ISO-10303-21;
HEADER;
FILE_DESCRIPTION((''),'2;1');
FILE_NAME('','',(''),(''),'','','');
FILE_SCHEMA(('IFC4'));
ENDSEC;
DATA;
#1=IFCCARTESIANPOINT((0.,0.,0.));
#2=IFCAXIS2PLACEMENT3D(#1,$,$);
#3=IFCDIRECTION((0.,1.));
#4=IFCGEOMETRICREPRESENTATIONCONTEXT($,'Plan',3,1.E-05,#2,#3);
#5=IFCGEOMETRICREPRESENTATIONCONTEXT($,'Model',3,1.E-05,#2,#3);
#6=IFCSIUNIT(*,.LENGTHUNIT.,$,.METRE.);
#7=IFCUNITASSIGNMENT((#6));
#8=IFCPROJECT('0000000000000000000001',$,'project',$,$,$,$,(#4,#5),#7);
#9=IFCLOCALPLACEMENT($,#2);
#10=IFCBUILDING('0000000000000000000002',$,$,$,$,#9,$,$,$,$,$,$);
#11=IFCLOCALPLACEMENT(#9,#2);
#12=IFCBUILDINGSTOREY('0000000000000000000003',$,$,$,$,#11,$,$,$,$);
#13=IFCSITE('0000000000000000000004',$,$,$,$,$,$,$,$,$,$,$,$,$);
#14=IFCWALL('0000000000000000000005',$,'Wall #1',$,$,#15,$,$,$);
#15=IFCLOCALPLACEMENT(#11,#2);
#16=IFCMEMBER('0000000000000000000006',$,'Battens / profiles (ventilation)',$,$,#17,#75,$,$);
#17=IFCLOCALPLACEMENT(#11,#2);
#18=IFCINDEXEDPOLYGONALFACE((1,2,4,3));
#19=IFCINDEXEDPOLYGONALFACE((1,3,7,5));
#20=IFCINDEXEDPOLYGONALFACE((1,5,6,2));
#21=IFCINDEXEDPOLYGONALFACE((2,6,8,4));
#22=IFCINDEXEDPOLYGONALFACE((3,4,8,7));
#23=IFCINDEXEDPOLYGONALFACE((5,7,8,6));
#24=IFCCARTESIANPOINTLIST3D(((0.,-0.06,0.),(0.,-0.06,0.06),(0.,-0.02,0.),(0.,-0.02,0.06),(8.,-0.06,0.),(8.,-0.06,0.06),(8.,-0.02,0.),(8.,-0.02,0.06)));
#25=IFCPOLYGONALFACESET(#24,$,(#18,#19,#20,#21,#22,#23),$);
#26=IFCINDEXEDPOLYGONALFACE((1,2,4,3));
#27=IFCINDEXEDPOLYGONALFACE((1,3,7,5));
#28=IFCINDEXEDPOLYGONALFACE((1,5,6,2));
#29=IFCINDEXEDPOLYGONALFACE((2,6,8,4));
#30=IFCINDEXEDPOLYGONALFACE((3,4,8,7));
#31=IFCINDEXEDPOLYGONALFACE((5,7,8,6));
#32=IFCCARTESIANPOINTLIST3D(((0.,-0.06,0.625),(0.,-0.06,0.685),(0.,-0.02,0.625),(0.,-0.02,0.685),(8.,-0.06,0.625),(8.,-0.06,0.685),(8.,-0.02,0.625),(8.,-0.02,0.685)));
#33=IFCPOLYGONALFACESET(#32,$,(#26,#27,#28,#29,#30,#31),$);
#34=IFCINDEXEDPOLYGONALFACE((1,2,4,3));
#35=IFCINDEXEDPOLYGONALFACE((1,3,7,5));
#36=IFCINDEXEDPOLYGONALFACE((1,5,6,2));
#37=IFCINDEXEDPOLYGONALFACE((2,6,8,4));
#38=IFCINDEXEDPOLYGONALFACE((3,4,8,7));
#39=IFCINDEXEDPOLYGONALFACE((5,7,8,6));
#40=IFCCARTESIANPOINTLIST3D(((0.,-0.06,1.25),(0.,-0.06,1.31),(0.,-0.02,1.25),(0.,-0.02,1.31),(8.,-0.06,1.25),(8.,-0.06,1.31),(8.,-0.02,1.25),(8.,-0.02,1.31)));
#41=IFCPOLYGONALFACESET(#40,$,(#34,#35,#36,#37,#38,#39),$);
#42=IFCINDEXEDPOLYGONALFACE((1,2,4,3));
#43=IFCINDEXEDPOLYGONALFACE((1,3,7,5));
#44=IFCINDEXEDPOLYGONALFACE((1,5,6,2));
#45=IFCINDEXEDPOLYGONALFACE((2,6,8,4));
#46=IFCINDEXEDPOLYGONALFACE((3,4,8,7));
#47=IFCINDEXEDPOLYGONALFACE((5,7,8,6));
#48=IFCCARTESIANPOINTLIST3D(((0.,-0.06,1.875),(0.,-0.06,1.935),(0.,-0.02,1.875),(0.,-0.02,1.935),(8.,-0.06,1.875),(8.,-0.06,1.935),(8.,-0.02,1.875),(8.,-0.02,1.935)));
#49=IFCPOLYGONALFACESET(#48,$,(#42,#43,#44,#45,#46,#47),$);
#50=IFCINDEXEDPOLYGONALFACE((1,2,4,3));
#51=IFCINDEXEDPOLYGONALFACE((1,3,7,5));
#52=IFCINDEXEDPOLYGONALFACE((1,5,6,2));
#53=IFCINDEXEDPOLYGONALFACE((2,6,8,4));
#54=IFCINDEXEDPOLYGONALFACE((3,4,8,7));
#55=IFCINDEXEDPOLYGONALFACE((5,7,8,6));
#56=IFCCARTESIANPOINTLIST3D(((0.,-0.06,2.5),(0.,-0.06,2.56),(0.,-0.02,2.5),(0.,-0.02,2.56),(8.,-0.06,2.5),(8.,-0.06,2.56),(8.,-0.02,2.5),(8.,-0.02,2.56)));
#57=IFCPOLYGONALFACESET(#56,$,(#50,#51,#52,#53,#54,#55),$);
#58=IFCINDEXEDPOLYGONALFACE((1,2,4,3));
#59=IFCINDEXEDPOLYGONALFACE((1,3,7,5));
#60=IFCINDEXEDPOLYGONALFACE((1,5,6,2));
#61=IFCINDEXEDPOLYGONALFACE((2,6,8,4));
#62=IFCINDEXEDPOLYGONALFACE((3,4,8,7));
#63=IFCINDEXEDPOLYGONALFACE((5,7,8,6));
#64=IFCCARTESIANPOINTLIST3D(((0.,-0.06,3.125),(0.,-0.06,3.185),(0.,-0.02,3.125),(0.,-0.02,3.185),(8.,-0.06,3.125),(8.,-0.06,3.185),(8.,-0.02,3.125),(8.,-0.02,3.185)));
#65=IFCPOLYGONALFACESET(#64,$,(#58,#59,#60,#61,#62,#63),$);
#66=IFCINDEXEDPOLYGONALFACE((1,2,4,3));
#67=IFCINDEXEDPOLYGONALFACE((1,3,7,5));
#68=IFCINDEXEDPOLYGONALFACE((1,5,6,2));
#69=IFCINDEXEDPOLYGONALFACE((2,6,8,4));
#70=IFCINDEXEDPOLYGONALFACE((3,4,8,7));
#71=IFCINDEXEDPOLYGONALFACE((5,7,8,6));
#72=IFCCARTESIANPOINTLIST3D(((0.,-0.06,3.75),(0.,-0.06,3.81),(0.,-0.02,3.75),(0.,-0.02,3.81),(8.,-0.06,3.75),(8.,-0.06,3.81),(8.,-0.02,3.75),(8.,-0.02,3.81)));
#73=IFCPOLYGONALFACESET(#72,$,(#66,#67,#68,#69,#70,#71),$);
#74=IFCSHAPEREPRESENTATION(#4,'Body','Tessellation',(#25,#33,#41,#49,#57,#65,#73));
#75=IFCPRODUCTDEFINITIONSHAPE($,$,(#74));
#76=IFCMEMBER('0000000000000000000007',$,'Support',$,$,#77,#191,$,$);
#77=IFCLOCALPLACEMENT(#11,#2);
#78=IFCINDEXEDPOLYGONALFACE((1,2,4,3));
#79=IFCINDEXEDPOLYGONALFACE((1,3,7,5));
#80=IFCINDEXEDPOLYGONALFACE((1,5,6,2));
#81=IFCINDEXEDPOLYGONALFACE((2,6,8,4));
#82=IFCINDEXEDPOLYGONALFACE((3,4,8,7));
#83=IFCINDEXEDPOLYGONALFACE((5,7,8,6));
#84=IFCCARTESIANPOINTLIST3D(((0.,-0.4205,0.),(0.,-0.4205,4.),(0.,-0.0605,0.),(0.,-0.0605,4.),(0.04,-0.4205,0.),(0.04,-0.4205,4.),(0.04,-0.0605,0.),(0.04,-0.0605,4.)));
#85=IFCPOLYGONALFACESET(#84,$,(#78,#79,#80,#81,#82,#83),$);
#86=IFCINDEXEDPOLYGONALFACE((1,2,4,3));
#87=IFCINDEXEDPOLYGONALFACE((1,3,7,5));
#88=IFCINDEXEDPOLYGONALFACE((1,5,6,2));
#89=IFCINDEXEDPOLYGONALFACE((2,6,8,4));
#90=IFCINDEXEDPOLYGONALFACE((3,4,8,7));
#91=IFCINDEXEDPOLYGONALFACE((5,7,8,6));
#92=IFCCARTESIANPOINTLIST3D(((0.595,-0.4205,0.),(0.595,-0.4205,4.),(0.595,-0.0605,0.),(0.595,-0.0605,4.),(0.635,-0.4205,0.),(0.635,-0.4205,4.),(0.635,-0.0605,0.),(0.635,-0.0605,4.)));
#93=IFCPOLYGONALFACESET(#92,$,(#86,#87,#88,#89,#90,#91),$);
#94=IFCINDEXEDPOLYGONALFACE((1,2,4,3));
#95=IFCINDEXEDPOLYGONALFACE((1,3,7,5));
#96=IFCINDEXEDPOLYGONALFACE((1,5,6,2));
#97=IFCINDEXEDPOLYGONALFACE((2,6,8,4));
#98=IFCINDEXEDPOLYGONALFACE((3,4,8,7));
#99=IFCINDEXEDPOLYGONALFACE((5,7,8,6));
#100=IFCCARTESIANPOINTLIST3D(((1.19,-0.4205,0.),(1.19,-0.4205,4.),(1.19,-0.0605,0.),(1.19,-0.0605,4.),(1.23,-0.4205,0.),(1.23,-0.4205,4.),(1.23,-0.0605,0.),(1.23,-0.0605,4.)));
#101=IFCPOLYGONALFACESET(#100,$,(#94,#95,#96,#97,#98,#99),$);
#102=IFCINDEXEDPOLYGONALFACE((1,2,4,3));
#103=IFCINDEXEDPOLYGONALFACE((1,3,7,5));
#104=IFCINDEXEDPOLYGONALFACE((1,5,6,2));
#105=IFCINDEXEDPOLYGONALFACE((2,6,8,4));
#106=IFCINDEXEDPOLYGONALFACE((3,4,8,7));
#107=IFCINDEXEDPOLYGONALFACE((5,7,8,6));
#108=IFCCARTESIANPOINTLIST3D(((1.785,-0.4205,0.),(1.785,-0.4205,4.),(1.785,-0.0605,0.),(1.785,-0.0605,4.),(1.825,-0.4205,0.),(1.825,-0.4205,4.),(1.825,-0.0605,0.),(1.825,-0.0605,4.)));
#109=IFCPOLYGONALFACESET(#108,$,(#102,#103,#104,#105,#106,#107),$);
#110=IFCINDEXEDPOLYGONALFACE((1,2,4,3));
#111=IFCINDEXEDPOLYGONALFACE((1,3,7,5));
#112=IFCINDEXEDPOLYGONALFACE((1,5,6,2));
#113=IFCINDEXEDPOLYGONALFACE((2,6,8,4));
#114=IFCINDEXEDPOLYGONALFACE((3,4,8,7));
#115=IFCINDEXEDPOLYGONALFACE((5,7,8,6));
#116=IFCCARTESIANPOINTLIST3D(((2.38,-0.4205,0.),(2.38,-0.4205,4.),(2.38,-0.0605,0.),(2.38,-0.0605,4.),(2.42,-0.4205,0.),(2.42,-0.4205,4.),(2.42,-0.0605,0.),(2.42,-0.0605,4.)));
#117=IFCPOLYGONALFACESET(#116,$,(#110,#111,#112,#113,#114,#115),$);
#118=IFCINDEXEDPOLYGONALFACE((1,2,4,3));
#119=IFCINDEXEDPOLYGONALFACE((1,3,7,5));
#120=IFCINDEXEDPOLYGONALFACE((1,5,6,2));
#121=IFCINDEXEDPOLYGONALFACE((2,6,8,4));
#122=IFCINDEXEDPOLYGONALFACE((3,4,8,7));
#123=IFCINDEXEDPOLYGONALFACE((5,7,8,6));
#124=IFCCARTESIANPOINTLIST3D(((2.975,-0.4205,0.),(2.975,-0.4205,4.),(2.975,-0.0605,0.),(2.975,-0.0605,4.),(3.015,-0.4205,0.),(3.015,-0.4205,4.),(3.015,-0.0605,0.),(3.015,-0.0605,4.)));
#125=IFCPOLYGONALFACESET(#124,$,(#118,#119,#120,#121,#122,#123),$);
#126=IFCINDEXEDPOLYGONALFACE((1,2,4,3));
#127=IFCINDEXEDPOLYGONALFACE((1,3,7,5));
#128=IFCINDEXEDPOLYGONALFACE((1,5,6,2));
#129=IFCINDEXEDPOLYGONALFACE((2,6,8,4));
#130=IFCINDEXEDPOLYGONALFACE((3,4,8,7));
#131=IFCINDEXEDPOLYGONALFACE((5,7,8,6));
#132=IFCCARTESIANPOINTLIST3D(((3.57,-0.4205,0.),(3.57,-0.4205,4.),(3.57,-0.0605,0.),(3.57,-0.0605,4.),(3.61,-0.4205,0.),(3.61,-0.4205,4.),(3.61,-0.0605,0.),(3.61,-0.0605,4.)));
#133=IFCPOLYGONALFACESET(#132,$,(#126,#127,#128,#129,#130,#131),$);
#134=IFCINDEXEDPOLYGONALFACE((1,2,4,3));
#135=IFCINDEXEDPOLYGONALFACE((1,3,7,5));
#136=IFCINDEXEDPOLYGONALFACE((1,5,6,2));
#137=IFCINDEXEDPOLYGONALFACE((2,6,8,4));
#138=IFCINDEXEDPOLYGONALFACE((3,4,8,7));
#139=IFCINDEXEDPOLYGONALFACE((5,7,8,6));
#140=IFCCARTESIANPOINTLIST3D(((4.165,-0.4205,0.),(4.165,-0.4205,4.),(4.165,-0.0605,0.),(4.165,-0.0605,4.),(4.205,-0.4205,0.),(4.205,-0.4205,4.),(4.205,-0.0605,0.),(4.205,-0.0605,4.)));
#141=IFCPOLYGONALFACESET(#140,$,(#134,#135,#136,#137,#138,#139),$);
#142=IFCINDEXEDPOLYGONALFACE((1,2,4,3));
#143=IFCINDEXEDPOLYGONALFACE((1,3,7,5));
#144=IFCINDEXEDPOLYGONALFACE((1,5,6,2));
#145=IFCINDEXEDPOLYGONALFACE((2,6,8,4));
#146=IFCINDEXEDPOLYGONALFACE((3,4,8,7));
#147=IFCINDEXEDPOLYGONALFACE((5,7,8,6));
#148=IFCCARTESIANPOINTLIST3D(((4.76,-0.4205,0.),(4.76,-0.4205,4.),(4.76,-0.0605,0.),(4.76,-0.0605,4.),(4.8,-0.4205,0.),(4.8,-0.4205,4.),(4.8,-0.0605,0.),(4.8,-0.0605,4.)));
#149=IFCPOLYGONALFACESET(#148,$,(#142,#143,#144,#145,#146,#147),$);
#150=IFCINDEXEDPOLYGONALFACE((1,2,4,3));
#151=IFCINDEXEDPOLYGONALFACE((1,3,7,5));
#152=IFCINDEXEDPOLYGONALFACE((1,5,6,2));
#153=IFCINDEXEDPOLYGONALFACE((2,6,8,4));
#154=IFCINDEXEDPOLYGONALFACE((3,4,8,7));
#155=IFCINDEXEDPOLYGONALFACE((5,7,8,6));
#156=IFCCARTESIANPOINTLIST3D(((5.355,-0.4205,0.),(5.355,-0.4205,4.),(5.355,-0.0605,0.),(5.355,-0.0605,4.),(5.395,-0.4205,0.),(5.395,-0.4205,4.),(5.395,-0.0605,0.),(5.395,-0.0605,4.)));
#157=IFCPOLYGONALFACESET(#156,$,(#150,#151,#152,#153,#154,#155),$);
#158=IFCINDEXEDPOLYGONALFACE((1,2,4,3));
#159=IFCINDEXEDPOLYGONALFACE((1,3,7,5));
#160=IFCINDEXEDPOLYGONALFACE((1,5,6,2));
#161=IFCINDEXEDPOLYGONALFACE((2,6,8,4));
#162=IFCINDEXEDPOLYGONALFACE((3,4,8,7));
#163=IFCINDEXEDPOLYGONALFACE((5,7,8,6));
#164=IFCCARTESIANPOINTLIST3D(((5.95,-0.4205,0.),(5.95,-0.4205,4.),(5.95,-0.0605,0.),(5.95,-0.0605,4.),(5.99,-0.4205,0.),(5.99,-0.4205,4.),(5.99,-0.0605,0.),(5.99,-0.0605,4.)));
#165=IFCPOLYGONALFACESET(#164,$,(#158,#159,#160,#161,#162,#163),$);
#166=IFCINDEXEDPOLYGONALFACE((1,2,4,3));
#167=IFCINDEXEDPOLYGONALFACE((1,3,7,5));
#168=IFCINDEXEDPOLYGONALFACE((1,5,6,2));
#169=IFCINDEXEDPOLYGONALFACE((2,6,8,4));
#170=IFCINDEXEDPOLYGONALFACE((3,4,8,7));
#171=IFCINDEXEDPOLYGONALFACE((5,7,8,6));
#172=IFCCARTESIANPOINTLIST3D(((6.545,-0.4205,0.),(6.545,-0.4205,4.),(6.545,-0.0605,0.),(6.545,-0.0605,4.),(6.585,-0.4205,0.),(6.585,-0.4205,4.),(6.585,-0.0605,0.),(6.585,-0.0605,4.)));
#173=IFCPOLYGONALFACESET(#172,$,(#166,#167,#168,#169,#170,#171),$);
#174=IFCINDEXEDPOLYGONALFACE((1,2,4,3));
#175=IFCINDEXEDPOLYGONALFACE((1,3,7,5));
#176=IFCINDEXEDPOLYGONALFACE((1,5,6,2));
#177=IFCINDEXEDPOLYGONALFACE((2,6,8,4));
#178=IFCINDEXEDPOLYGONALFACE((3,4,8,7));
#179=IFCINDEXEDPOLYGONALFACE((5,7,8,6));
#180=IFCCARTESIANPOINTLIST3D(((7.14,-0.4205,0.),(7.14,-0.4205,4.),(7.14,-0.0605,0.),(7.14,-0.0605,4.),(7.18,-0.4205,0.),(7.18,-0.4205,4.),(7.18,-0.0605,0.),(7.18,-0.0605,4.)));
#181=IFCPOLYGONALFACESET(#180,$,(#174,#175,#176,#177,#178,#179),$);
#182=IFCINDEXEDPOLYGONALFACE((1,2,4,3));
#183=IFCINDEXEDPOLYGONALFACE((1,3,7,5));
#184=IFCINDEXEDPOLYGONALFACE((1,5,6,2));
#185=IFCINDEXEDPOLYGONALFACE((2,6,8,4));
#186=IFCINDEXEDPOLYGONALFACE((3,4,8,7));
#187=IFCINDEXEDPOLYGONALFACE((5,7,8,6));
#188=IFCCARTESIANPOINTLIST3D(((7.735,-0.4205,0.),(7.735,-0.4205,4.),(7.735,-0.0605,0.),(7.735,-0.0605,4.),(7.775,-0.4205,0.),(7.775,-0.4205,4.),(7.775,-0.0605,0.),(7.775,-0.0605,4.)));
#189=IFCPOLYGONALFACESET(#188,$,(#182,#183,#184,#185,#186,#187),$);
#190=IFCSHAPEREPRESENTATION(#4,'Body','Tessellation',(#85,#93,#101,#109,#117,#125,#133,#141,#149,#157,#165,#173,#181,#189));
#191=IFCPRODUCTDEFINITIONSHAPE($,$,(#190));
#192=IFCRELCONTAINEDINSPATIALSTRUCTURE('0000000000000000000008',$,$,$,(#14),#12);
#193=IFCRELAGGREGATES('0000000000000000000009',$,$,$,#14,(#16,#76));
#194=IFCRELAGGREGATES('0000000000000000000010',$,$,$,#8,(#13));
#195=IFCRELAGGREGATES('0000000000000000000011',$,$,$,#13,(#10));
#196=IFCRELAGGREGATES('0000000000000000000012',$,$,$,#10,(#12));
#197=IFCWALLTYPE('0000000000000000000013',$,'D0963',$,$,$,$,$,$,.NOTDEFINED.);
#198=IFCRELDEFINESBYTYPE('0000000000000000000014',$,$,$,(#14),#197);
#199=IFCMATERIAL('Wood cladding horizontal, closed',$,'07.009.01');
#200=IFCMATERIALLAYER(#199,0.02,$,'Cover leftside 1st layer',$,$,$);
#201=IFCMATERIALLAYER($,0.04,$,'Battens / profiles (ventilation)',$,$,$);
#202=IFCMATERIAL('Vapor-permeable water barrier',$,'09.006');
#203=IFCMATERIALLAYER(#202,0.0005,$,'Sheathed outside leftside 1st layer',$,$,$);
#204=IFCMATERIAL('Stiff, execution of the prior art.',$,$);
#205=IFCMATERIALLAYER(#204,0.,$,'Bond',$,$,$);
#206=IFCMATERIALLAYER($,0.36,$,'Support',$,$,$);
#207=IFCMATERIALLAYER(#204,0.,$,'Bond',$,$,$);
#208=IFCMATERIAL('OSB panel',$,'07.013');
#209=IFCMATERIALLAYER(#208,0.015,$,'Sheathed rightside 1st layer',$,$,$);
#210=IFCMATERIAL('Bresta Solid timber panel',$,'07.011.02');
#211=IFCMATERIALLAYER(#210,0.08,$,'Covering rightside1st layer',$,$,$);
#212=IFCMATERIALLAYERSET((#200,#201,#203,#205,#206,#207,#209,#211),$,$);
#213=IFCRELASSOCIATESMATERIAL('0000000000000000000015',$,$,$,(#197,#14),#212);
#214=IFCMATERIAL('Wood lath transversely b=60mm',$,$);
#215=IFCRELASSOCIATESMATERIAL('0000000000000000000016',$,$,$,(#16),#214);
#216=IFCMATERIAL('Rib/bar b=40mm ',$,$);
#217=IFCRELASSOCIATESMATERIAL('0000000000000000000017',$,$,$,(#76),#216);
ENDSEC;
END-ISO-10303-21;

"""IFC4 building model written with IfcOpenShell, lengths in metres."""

from ifc_helpers import new_model, si_unit, direction, frame, frame_2d, origin, place, context, project, spatial, rectangle, extrude, material, layer, layer_set, type_object, element, aggregate, save


model = new_model("IFC4")

# Units and contexts
plan_context = context("Plan", 3, precision=1e-05, world=origin(), true_north=direction((0.0, 1.0)))
model_context = context("Model", 3, precision=1e-05, world=origin(), true_north=direction((0.0, 1.0)))
ifc_project = project(units=[si_unit("LENGTHUNIT", "METRE")], contexts=[plan_context, model_context])

# Site, building, storey
site = spatial("IfcSite", under=ifc_project)
building_placement = place(None, origin())
building = spatial("IfcBuilding", under=site, at=building_placement)
storey_placement = place(building_placement, origin())
storey = spatial("IfcBuildingStorey", under=building, at=storey_placement)

# Wall, members
ifc_material_1 = material(Name="Wood cladding horizontal, closed", Category="07.009.01")
ifc_layer_1 = layer(ifc_material_1, 0.02, Name="Cover leftside 1st layer")
ifc_layer_2 = layer(None, 0.04, Name="Battens / profiles (ventilation)")
ifc_material_2 = material(Name="Vapor-permeable water barrier", Category="09.006")
ifc_layer_3 = layer(ifc_material_2, 0.0005, Name="Sheathed outside leftside 1st layer")
ifc_material_3 = material(Name="Stiff, execution of the prior art.")
ifc_layer_4 = layer(ifc_material_3, 0.0, Name="Bond")
ifc_layer_5 = layer(None, 0.36, Name="Support")
ifc_layer_6 = layer(ifc_material_3, 0.0, Name="Bond")
ifc_material_4 = material(Name="OSB panel", Category="07.013")
ifc_layer_7 = layer(ifc_material_4, 0.015, Name="Sheathed rightside 1st layer")
ifc_material_5 = material(Name="Bresta Solid timber panel", Category="07.011.02")
ifc_layer_8 = layer(ifc_material_5, 0.08, Name="Covering rightside1st layer")
ifc_layer_set = layer_set([ifc_layer_1, ifc_layer_2, ifc_layer_3, ifc_layer_4, ifc_layer_5, ifc_layer_6, ifc_layer_7, ifc_layer_8])
wall_type = type_object("IfcWallType", Name="D0963", PredefinedType="NOTDEFINED", material=ifc_layer_set)
wall_placement = place(None, frame((0.0, 0.0, 0.0), z_axis=(0.0, -1.0, 0.0), x_axis=(1.0, 0.0, 0.0)))
wall = element("IfcWall", 1, at=wall_placement, inside=storey, type_object=wall_type, material=ifc_layer_set, Name="Wall #1")
ifc_material_6 = material(Name="Wood lath transversely b=60mm")
member_1_placement = place(wall_placement, origin())
member_1 = element("IfcMember", 2, at=member_1_placement, material=ifc_material_6, Name="Battens / profiles (ventilation)", context=plan_context, shape_type="SweptSolid", body=[
    extrude(rectangle(XDim=0.06, YDim=0.04, at=frame_2d((0.03, 0.02), x_axis=(1.0, 0.0))), frame((0.0, 0.0, 0.02), z_axis=(1.0, 0.0, 0.0), x_axis=(0.0, 1.0, 0.0)), (0.0, 0.0, 1.0), 8.0),
    extrude(rectangle(XDim=0.06, YDim=0.04, at=frame_2d((0.03, 0.02), x_axis=(1.0, 0.0))), frame((0.0, 0.625, 0.02), z_axis=(1.0, 0.0, 0.0), x_axis=(0.0, 1.0, 0.0)), (0.0, 0.0, 1.0), 8.0),
    extrude(rectangle(XDim=0.06, YDim=0.04, at=frame_2d((0.03, 0.02), x_axis=(1.0, 0.0))), frame((0.0, 1.25, 0.02), z_axis=(1.0, 0.0, 0.0), x_axis=(0.0, 1.0, 0.0)), (0.0, 0.0, 1.0), 8.0),
    extrude(rectangle(XDim=0.06, YDim=0.04, at=frame_2d((0.03, 0.02), x_axis=(1.0, 0.0))), frame((0.0, 1.875, 0.02), z_axis=(1.0, 0.0, 0.0), x_axis=(0.0, 1.0, 0.0)), (0.0, 0.0, 1.0), 8.0),
    extrude(rectangle(XDim=0.06, YDim=0.04, at=frame_2d((0.03, 0.02), x_axis=(1.0, 0.0))), frame((0.0, 2.5, 0.02), z_axis=(1.0, 0.0, 0.0), x_axis=(0.0, 1.0, 0.0)), (0.0, 0.0, 1.0), 8.0),
    extrude(rectangle(XDim=0.06, YDim=0.04, at=frame_2d((0.03, 0.02), x_axis=(1.0, 0.0))), frame((0.0, 3.125, 0.02), z_axis=(1.0, 0.0, 0.0), x_axis=(0.0, 1.0, 0.0)), (0.0, 0.0, 1.0), 8.0),
    extrude(rectangle(XDim=0.06, YDim=0.04, at=frame_2d((0.03, 0.02), x_axis=(1.0, 0.0))), frame((0.0, 3.75, 0.02), z_axis=(1.0, 0.0, 0.0), x_axis=(0.0, 1.0, 0.0)), (0.0, 0.0, 1.0), 8.0),
])
ifc_material_7 = material(Name="Rib/bar b=40mm ")
member_2_placement = place(wall_placement, origin())
member_2 = element("IfcMember", 3, at=member_2_placement, material=ifc_material_7, Name="Support", context=plan_context, shape_type="SweptSolid", body=[
    extrude(rectangle(XDim=0.04, YDim=0.36, at=frame_2d((0.02, 0.18), x_axis=(1.0, 0.0))), frame((0.0, 4.0, 0.0605), z_axis=(0.0, -1.0, 0.0), x_axis=(1.0, 0.0, 0.0)), (0.0, 0.0, 1.0), 4.0),
    extrude(rectangle(XDim=0.04, YDim=0.36, at=frame_2d((0.02, 0.18), x_axis=(1.0, 0.0))), frame((0.595, 4.0, 0.0605), z_axis=(0.0, -1.0, 0.0), x_axis=(1.0, 0.0, 0.0)), (0.0, 0.0, 1.0), 4.0),
    extrude(rectangle(XDim=0.04, YDim=0.36, at=frame_2d((0.02, 0.18), x_axis=(1.0, 0.0))), frame((1.19, 4.0, 0.0605), z_axis=(0.0, -1.0, 0.0), x_axis=(1.0, 0.0, 0.0)), (0.0, 0.0, 1.0), 4.0),
    extrude(rectangle(XDim=0.04, YDim=0.36, at=frame_2d((0.02, 0.18), x_axis=(1.0, 0.0))), frame((1.785, 4.0, 0.0605), z_axis=(0.0, -1.0, 0.0), x_axis=(1.0, 0.0, 0.0)), (0.0, 0.0, 1.0), 4.0),
    extrude(rectangle(XDim=0.04, YDim=0.36, at=frame_2d((0.02, 0.18), x_axis=(1.0, 0.0))), frame((2.38, 4.0, 0.0605), z_axis=(0.0, -1.0, 0.0), x_axis=(1.0, 0.0, 0.0)), (0.0, 0.0, 1.0), 4.0),
    extrude(rectangle(XDim=0.04, YDim=0.36, at=frame_2d((0.02, 0.18), x_axis=(1.0, 0.0))), frame((2.975, 4.0, 0.0605), z_axis=(0.0, -1.0, 0.0), x_axis=(1.0, 0.0, 0.0)), (0.0, 0.0, 1.0), 4.0),
    extrude(rectangle(XDim=0.04, YDim=0.36, at=frame_2d((0.02, 0.18), x_axis=(1.0, 0.0))), frame((3.57, 4.0, 0.0605), z_axis=(0.0, -1.0, 0.0), x_axis=(1.0, 0.0, 0.0)), (0.0, 0.0, 1.0), 4.0),
    extrude(rectangle(XDim=0.04, YDim=0.36, at=frame_2d((0.02, 0.18), x_axis=(1.0, 0.0))), frame((4.165, 4.0, 0.0605), z_axis=(0.0, -1.0, 0.0), x_axis=(1.0, 0.0, 0.0)), (0.0, 0.0, 1.0), 4.0),
    extrude(rectangle(XDim=0.04, YDim=0.36, at=frame_2d((0.02, 0.18), x_axis=(1.0, 0.0))), frame((4.76, 4.0, 0.0605), z_axis=(0.0, -1.0, 0.0), x_axis=(1.0, 0.0, 0.0)), (0.0, 0.0, 1.0), 4.0),
    extrude(rectangle(XDim=0.04, YDim=0.36, at=frame_2d((0.02, 0.18), x_axis=(1.0, 0.0))), frame((5.355, 4.0, 0.0605), z_axis=(0.0, -1.0, 0.0), x_axis=(1.0, 0.0, 0.0)), (0.0, 0.0, 1.0), 4.0),
    extrude(rectangle(XDim=0.04, YDim=0.36, at=frame_2d((0.02, 0.18), x_axis=(1.0, 0.0))), frame((5.95, 4.0, 0.0605), z_axis=(0.0, -1.0, 0.0), x_axis=(1.0, 0.0, 0.0)), (0.0, 0.0, 1.0), 4.0),
    extrude(rectangle(XDim=0.04, YDim=0.36, at=frame_2d((0.02, 0.18), x_axis=(1.0, 0.0))), frame((6.545, 4.0, 0.0605), z_axis=(0.0, -1.0, 0.0), x_axis=(1.0, 0.0, 0.0)), (0.0, 0.0, 1.0), 4.0),
    extrude(rectangle(XDim=0.04, YDim=0.36, at=frame_2d((0.02, 0.18), x_axis=(1.0, 0.0))), frame((7.14, 4.0, 0.0605), z_axis=(0.0, -1.0, 0.0), x_axis=(1.0, 0.0, 0.0)), (0.0, 0.0, 1.0), 4.0),
    extrude(rectangle(XDim=0.04, YDim=0.36, at=frame_2d((0.02, 0.18), x_axis=(1.0, 0.0))), frame((7.735, 4.0, 0.0605), z_axis=(0.0, -1.0, 0.0), x_axis=(1.0, 0.0, 0.0)), (0.0, 0.0, 1.0), 4.0),
])
aggregate(wall, [member_1, member_2])

save(model, "model.ifc")
